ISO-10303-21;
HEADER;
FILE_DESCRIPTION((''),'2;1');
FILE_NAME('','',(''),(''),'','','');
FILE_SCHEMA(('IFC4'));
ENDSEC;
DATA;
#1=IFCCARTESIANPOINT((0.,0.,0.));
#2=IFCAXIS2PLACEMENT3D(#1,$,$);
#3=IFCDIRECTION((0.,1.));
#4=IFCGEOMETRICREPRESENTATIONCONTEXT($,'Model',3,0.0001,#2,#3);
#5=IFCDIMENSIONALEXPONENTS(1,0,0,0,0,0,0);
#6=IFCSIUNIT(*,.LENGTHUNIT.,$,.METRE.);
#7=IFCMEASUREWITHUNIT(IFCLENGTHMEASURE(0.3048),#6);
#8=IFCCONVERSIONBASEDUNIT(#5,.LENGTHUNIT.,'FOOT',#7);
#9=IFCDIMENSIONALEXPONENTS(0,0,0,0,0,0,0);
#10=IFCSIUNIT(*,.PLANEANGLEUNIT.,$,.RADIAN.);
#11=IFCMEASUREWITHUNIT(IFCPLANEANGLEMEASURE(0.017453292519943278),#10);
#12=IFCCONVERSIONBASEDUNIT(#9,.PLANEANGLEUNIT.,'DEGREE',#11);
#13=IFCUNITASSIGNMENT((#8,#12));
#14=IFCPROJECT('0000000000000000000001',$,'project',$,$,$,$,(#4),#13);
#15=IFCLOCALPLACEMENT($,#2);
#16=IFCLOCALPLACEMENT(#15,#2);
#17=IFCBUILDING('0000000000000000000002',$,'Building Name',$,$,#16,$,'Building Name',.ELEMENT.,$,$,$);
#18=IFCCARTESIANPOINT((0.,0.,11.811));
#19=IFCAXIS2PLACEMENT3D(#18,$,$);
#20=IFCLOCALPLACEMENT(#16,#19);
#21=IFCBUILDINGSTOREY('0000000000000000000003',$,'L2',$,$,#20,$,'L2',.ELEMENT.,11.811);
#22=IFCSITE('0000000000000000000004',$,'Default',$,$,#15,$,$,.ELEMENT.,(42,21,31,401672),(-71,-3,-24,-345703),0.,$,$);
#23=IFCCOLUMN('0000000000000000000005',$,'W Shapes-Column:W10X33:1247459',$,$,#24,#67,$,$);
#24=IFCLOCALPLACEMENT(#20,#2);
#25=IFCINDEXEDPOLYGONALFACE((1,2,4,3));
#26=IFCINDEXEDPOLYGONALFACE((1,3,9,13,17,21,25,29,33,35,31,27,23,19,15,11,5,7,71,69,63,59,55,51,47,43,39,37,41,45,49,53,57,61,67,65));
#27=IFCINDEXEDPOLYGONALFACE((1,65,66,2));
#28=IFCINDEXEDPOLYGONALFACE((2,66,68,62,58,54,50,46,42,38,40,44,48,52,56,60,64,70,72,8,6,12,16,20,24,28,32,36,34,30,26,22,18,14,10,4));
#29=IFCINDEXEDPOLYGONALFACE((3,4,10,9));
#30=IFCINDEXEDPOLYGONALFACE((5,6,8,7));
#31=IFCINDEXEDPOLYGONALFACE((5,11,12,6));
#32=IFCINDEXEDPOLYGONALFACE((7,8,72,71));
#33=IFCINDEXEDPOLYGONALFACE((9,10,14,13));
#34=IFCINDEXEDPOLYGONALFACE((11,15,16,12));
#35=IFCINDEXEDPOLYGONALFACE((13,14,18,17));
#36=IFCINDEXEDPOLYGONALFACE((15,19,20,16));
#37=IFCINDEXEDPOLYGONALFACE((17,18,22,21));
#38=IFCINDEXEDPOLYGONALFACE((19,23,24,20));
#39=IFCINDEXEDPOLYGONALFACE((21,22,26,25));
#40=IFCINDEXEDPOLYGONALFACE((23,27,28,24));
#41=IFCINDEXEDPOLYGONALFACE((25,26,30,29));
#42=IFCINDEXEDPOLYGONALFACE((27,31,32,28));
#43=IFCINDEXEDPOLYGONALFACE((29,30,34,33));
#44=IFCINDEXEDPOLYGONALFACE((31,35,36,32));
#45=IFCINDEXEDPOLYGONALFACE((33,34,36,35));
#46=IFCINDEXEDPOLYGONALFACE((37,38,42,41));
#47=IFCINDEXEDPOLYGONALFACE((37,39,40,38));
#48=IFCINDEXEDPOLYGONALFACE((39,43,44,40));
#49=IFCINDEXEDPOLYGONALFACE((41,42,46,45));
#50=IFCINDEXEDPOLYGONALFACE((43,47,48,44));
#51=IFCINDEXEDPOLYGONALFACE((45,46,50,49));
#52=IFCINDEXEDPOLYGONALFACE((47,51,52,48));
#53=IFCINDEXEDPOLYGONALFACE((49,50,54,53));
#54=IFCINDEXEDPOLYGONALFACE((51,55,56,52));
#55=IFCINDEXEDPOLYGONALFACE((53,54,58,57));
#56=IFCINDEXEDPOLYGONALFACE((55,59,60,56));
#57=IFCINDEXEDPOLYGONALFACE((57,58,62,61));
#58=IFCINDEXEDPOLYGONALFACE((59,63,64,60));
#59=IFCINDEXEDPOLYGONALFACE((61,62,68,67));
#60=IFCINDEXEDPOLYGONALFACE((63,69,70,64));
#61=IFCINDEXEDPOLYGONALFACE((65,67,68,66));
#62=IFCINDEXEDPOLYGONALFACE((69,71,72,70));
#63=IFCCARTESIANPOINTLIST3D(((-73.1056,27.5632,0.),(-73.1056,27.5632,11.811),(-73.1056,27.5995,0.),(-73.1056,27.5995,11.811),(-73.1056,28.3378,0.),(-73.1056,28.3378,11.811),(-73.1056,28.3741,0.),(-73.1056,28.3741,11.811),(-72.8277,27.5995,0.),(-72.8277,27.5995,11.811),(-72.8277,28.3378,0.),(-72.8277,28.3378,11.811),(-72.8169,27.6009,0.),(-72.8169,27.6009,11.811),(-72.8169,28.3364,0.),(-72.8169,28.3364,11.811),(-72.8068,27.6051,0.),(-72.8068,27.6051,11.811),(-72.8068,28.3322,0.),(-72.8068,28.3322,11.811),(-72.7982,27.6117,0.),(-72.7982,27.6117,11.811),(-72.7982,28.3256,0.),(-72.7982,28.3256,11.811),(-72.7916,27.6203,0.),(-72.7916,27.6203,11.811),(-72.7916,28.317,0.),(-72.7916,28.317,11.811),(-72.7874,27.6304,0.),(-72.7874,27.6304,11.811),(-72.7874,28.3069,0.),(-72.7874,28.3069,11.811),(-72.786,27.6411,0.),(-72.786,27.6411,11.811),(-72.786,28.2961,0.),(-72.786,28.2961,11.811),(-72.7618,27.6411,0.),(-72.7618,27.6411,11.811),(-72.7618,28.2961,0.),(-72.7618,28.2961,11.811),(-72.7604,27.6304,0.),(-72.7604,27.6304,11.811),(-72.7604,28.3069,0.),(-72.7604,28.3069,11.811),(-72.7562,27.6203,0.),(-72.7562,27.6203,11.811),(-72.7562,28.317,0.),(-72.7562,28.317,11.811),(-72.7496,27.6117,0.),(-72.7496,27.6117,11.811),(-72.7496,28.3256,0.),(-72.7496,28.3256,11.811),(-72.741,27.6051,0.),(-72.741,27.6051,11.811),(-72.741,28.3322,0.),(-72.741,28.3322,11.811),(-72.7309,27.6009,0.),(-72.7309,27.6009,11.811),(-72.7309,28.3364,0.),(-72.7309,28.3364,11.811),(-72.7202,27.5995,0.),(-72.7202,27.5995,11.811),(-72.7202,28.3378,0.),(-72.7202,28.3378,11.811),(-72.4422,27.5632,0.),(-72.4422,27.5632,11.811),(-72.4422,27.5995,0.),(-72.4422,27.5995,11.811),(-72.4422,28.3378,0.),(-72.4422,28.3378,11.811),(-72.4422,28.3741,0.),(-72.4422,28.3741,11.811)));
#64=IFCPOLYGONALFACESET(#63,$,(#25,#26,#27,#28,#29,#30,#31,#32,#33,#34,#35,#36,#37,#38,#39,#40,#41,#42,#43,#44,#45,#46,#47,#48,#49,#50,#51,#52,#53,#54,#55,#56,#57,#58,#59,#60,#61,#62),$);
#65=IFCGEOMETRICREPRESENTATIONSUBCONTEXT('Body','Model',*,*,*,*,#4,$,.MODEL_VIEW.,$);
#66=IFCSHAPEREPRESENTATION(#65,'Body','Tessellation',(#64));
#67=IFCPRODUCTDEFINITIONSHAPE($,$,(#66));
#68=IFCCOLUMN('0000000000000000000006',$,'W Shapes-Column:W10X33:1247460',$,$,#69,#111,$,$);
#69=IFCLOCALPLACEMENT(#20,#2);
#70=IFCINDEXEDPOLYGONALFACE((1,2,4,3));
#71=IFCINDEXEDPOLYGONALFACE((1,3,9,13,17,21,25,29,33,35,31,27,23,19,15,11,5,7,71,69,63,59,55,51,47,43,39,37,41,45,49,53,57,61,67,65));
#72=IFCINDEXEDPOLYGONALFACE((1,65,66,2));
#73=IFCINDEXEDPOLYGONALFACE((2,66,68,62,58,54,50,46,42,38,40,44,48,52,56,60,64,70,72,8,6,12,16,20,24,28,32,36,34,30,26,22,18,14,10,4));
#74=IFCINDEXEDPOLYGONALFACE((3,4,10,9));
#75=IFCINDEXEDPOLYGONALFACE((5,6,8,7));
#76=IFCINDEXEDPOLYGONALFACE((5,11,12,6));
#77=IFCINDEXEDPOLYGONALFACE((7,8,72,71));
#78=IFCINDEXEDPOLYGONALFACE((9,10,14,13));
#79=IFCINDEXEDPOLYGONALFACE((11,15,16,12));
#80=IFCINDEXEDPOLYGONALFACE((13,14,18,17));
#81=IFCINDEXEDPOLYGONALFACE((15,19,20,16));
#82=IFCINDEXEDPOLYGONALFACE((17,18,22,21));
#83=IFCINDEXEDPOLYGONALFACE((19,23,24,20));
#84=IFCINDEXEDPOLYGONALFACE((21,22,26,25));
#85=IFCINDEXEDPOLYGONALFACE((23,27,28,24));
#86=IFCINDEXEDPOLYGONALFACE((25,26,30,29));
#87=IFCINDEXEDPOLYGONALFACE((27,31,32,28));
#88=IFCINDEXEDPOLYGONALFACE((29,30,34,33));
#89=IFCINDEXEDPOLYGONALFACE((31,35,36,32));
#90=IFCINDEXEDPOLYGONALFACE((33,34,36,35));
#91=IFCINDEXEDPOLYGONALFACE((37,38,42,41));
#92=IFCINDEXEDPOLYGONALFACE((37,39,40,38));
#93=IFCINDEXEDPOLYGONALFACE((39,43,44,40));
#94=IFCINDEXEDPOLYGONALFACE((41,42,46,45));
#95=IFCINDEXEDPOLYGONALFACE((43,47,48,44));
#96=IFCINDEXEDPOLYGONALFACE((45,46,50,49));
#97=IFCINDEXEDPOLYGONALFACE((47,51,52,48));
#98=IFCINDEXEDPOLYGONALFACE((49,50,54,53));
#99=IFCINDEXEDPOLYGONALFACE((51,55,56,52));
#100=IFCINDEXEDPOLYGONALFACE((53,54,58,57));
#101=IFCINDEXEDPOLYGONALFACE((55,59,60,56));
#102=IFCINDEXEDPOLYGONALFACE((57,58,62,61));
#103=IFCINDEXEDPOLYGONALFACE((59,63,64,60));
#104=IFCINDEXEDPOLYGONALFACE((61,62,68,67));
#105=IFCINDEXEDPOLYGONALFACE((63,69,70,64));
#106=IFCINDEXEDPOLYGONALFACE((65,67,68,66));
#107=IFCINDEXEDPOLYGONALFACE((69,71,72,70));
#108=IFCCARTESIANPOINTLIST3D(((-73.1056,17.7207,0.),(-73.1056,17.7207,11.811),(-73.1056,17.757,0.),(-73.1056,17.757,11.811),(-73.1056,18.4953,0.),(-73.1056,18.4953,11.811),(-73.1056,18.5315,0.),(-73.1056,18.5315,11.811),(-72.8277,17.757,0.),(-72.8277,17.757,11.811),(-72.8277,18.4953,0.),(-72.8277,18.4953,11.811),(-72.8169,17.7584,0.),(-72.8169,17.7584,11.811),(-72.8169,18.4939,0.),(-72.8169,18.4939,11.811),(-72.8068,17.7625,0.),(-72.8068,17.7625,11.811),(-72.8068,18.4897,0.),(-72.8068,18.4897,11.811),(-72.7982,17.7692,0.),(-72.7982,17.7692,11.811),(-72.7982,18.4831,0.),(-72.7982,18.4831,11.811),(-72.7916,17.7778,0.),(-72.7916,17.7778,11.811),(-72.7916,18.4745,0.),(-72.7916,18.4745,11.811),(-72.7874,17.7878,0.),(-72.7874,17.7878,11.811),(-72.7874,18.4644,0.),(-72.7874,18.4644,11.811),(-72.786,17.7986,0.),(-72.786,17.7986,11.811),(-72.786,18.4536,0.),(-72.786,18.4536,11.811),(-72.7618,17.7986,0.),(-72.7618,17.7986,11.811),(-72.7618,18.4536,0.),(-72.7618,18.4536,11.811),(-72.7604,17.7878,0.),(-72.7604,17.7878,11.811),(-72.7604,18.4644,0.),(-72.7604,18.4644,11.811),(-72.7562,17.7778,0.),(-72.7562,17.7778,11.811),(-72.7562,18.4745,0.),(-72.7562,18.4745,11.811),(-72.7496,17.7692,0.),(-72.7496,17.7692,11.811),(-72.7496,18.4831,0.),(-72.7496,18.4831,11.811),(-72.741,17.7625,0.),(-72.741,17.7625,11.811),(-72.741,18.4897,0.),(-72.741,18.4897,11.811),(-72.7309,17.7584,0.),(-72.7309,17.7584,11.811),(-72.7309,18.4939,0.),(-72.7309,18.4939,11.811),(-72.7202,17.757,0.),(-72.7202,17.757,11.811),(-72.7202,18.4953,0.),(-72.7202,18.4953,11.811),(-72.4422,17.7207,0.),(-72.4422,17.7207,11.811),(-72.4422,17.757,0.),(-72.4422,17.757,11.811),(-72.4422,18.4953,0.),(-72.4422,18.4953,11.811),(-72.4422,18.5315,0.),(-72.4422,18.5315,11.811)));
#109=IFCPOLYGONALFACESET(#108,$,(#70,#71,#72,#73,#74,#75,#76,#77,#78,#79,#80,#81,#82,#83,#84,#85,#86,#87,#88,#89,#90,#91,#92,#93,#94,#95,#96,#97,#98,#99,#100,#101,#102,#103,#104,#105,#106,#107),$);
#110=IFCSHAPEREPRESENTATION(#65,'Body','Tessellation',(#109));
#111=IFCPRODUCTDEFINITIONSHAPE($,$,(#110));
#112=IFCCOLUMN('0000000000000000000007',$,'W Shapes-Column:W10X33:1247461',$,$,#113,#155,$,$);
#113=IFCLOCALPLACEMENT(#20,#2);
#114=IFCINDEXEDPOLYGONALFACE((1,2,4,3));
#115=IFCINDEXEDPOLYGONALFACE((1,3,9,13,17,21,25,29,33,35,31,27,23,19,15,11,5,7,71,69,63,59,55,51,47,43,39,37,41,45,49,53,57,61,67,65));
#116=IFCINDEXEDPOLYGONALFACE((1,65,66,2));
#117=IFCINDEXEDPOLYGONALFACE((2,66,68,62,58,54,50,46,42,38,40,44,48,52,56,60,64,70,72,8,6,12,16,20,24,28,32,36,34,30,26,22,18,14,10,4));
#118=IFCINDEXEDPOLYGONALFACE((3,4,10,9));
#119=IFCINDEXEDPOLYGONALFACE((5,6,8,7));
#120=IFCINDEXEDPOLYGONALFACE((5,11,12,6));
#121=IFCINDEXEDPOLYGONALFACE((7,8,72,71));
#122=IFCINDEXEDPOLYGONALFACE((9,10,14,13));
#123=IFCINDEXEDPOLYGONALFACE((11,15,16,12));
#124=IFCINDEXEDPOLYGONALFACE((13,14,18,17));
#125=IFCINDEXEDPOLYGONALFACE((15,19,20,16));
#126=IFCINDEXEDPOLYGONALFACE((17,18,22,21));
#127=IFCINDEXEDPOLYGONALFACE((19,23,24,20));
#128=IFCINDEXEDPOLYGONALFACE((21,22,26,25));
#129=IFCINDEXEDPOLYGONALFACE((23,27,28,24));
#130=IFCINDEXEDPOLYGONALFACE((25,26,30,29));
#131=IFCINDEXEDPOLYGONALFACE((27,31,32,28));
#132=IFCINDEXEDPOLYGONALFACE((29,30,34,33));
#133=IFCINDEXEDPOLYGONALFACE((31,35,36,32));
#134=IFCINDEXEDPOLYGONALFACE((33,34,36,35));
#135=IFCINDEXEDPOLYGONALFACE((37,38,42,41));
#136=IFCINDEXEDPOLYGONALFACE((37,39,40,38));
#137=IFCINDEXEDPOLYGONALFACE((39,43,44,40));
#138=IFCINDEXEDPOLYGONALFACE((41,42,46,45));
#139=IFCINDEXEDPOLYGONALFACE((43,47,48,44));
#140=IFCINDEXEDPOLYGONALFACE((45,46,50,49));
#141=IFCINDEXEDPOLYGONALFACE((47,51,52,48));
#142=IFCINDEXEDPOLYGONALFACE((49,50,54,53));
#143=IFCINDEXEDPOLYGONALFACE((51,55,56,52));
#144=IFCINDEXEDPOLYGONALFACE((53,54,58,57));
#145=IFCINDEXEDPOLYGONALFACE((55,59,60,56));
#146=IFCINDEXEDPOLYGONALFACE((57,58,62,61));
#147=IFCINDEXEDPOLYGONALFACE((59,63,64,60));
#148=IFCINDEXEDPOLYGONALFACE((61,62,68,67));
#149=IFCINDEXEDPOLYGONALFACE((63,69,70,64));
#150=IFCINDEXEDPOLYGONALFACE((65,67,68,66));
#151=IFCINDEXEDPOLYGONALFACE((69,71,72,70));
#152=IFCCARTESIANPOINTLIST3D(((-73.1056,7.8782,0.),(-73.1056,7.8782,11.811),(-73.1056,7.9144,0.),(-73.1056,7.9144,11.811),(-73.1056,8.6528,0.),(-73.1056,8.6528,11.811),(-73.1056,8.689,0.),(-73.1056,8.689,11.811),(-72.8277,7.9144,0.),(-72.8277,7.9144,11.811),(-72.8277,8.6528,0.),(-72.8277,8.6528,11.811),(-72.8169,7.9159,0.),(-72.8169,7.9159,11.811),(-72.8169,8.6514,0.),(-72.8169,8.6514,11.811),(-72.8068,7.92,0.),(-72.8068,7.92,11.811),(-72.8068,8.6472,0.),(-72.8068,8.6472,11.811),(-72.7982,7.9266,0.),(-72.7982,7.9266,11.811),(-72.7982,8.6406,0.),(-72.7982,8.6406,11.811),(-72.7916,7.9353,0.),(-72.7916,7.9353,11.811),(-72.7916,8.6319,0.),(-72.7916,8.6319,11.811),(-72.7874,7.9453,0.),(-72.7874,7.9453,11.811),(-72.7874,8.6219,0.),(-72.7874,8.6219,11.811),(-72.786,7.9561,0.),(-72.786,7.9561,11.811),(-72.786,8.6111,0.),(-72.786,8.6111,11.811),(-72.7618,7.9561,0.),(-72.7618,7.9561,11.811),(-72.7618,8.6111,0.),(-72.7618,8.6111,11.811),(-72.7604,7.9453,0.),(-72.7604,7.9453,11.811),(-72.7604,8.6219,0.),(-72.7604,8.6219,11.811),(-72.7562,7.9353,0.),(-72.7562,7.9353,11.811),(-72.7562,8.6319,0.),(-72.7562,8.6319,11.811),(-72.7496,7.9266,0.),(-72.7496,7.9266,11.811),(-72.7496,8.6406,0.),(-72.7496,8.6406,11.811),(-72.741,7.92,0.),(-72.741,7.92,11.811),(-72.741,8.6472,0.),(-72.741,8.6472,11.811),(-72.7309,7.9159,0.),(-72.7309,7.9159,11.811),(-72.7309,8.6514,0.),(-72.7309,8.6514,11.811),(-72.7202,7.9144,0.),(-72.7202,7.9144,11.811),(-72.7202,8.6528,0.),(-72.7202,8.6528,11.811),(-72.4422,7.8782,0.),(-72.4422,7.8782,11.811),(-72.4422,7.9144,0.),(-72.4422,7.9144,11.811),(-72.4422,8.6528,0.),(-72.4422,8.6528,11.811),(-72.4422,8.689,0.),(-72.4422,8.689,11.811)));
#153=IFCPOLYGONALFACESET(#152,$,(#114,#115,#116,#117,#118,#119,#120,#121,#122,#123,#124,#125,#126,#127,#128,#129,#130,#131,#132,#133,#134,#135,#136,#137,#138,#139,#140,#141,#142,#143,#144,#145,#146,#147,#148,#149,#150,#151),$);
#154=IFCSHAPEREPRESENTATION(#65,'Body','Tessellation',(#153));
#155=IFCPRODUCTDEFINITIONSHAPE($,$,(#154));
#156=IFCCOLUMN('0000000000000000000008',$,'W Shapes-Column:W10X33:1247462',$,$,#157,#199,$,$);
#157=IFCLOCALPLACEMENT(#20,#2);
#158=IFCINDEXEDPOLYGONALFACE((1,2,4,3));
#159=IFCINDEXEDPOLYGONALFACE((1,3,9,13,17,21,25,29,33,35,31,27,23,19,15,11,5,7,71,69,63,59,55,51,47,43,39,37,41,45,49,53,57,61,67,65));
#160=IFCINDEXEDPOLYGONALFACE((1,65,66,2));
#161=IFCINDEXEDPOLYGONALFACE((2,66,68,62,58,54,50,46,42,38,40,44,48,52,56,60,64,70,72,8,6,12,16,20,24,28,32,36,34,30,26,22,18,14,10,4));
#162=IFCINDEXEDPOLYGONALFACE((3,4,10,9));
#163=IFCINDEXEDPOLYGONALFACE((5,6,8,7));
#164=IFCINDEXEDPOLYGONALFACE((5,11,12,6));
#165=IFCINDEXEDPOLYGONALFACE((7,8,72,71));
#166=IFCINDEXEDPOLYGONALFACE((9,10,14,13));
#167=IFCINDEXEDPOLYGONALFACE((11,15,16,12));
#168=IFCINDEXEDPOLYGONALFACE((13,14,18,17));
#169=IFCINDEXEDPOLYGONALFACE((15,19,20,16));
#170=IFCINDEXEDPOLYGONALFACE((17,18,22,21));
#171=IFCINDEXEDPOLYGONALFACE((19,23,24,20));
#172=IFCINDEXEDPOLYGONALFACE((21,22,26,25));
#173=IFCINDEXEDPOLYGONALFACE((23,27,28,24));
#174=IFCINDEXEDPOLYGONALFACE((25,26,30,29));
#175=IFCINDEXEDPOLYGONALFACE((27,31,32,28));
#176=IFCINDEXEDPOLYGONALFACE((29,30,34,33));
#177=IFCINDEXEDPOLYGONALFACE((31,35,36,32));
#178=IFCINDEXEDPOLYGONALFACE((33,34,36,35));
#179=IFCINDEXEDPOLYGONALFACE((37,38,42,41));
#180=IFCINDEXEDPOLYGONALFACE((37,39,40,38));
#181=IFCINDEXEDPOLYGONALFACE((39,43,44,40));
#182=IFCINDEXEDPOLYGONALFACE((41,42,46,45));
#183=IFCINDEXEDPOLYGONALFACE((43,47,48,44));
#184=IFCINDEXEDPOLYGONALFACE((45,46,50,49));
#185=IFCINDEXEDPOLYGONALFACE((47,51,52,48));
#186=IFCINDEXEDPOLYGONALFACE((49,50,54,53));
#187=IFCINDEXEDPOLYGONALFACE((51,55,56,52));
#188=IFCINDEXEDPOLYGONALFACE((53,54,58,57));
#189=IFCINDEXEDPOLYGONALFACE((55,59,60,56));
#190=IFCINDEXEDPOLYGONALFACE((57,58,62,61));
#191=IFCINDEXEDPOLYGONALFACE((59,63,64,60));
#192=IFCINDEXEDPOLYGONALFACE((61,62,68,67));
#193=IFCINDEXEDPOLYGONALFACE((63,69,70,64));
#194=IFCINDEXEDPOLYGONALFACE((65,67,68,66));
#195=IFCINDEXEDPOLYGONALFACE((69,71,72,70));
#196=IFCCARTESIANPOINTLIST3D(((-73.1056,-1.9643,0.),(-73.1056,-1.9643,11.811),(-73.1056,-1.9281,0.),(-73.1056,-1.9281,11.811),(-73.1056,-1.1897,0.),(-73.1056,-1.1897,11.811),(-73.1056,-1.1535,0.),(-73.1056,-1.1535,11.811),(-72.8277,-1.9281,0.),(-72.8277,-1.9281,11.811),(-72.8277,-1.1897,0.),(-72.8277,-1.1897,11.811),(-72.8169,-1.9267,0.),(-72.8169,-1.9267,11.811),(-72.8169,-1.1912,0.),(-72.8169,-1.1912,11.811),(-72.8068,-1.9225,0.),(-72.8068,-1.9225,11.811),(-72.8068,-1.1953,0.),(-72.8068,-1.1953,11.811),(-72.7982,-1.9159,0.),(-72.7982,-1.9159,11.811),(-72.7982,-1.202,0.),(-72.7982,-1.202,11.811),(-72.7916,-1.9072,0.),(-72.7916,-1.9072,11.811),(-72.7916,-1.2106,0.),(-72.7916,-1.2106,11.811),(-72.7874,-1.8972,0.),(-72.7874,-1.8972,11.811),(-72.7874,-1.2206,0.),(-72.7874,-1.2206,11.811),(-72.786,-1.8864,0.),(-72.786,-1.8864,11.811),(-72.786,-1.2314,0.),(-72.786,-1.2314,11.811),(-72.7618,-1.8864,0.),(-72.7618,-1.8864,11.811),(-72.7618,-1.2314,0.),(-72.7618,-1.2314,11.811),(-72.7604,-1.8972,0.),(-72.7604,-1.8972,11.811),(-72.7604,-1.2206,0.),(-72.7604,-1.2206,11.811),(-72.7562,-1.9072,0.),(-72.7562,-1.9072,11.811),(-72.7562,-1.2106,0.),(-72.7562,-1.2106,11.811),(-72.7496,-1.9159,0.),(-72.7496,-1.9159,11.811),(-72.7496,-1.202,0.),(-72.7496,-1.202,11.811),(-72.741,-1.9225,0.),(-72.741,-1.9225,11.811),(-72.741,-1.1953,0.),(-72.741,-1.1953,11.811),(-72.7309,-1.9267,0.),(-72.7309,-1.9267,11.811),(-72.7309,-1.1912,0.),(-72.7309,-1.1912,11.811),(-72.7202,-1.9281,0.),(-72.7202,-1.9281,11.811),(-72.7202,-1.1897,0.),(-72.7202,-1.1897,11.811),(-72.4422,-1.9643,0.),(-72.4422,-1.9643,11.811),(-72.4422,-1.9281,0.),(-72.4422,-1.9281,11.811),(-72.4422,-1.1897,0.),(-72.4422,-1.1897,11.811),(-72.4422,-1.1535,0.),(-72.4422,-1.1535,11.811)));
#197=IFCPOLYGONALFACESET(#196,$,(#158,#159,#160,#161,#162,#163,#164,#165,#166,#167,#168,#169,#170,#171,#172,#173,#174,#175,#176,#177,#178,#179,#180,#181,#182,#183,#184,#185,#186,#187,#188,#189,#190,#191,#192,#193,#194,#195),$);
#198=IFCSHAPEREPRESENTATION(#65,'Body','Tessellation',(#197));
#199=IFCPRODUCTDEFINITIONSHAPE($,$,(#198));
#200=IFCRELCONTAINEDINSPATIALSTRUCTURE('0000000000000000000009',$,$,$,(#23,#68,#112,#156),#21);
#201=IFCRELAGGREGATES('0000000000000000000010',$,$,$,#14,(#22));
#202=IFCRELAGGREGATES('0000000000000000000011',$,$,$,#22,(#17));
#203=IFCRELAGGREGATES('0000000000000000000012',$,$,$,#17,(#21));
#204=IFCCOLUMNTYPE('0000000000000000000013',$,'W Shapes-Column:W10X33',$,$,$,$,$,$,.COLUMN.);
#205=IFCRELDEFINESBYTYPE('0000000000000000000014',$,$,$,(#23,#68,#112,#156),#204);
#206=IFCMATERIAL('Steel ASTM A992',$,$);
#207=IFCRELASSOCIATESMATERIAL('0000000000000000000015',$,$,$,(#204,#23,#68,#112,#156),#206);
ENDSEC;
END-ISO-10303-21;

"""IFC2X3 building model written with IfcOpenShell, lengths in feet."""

from ifc_helpers import new_model, entity, si_unit, converted_unit, direction, frame, frame_2d, origin, place, context, subcontext, project, spatial, i_section, extrude, source, transform, mapped, material, type_object, type_shapes, element, save


model = new_model("IFC2X3")

# Units and contexts
model_context = context("Model", 3, precision=0.0001, world=origin(), true_north=direction((0.0, 1.0)))
body_context = subcontext(model_context, "Body", "Model", "MODEL_VIEW")
ifc_project = project(units=[converted_unit("LENGTHUNIT", "FOOT", entity("IfcLengthMeasure", 0.3048), si_unit("LENGTHUNIT", "METRE"), dimensions=[1, 0, 0, 0, 0, 0, 0]), converted_unit("PLANEANGLEUNIT", "DEGREE", entity("IfcPlaneAngleMeasure", 0.017453292519943278), si_unit("PLANEANGLEUNIT", "RADIAN"), dimensions=[0, 0, 0, 0, 0, 0, 0])], contexts=[model_context])

# Site, building, storey
site_placement = place(None, origin())
site = spatial("IfcSite", under=ifc_project, at=site_placement, Name="Default", CompositionType="ELEMENT", RefLatitude=(42, 21, 31, 401672), RefLongitude=(-71, -3, -24, -345703), RefElevation=0.0)
building_placement = place(site_placement, origin())
building = spatial("IfcBuilding", under=site, at=building_placement, Name="Building Name", LongName="Building Name", CompositionType="ELEMENT")
storey_placement = place(building_placement, frame((0.0, 0.0, 11.811)))
storey = spatial("IfcBuildingStorey", under=building, at=storey_placement, Name="L2", LongName="L2", CompositionType="ELEMENT", Elevation=11.811)

# Columns
ifc_material_1 = material(Name="Steel ASTM A992")
column_type = type_object("IfcColumnType", Name="W Shapes-Column:W10X33", PredefinedType="COLUMN", material=ifc_material_1)
shared_shape = source(origin(), body_context, "Body", "SweptSolid", [
    extrude(i_section(OverallWidth=0.6633, OverallDepth=0.8108, WebThickness=0.0242, FlangeThickness=0.0362, FilletRadius=0.0417, at=frame_2d((0.0, 0.0), x_axis=(1.0, 0.0))), frame((0.0, 0.0, 11.811), z_axis=(0.0, 0.0, 1.0), x_axis=(-1.0, 0.0, 0.0)), (0.0, 0.0, 1.0), 11.811),
])
type_shapes(column_type, [shared_shape])
for number, where, name in (
    (1, (-72.7739, 27.9686, -11.811), "W Shapes-Column:W10X33:1247459"),
    (2, (-72.7739, 18.1261, -11.811), "W Shapes-Column:W10X33:1247460"),
    (3, (-72.7739, 8.2836, -11.811), "W Shapes-Column:W10X33:1247461"),
    (4, (-72.7739, -1.5589, -11.811), "W Shapes-Column:W10X33:1247462"),
):
    element("IfcColumn", number, at=place(storey_placement, frame(where)), inside=storey, type_object=column_type, material=ifc_material_1, Name=name, context=body_context, shape_type="MappedRepresentation", body=[
        mapped(shared_shape, transform((0.0, 0.0, 0.0), scale=1.0)),
    ])

save(model, "model.ifc")
